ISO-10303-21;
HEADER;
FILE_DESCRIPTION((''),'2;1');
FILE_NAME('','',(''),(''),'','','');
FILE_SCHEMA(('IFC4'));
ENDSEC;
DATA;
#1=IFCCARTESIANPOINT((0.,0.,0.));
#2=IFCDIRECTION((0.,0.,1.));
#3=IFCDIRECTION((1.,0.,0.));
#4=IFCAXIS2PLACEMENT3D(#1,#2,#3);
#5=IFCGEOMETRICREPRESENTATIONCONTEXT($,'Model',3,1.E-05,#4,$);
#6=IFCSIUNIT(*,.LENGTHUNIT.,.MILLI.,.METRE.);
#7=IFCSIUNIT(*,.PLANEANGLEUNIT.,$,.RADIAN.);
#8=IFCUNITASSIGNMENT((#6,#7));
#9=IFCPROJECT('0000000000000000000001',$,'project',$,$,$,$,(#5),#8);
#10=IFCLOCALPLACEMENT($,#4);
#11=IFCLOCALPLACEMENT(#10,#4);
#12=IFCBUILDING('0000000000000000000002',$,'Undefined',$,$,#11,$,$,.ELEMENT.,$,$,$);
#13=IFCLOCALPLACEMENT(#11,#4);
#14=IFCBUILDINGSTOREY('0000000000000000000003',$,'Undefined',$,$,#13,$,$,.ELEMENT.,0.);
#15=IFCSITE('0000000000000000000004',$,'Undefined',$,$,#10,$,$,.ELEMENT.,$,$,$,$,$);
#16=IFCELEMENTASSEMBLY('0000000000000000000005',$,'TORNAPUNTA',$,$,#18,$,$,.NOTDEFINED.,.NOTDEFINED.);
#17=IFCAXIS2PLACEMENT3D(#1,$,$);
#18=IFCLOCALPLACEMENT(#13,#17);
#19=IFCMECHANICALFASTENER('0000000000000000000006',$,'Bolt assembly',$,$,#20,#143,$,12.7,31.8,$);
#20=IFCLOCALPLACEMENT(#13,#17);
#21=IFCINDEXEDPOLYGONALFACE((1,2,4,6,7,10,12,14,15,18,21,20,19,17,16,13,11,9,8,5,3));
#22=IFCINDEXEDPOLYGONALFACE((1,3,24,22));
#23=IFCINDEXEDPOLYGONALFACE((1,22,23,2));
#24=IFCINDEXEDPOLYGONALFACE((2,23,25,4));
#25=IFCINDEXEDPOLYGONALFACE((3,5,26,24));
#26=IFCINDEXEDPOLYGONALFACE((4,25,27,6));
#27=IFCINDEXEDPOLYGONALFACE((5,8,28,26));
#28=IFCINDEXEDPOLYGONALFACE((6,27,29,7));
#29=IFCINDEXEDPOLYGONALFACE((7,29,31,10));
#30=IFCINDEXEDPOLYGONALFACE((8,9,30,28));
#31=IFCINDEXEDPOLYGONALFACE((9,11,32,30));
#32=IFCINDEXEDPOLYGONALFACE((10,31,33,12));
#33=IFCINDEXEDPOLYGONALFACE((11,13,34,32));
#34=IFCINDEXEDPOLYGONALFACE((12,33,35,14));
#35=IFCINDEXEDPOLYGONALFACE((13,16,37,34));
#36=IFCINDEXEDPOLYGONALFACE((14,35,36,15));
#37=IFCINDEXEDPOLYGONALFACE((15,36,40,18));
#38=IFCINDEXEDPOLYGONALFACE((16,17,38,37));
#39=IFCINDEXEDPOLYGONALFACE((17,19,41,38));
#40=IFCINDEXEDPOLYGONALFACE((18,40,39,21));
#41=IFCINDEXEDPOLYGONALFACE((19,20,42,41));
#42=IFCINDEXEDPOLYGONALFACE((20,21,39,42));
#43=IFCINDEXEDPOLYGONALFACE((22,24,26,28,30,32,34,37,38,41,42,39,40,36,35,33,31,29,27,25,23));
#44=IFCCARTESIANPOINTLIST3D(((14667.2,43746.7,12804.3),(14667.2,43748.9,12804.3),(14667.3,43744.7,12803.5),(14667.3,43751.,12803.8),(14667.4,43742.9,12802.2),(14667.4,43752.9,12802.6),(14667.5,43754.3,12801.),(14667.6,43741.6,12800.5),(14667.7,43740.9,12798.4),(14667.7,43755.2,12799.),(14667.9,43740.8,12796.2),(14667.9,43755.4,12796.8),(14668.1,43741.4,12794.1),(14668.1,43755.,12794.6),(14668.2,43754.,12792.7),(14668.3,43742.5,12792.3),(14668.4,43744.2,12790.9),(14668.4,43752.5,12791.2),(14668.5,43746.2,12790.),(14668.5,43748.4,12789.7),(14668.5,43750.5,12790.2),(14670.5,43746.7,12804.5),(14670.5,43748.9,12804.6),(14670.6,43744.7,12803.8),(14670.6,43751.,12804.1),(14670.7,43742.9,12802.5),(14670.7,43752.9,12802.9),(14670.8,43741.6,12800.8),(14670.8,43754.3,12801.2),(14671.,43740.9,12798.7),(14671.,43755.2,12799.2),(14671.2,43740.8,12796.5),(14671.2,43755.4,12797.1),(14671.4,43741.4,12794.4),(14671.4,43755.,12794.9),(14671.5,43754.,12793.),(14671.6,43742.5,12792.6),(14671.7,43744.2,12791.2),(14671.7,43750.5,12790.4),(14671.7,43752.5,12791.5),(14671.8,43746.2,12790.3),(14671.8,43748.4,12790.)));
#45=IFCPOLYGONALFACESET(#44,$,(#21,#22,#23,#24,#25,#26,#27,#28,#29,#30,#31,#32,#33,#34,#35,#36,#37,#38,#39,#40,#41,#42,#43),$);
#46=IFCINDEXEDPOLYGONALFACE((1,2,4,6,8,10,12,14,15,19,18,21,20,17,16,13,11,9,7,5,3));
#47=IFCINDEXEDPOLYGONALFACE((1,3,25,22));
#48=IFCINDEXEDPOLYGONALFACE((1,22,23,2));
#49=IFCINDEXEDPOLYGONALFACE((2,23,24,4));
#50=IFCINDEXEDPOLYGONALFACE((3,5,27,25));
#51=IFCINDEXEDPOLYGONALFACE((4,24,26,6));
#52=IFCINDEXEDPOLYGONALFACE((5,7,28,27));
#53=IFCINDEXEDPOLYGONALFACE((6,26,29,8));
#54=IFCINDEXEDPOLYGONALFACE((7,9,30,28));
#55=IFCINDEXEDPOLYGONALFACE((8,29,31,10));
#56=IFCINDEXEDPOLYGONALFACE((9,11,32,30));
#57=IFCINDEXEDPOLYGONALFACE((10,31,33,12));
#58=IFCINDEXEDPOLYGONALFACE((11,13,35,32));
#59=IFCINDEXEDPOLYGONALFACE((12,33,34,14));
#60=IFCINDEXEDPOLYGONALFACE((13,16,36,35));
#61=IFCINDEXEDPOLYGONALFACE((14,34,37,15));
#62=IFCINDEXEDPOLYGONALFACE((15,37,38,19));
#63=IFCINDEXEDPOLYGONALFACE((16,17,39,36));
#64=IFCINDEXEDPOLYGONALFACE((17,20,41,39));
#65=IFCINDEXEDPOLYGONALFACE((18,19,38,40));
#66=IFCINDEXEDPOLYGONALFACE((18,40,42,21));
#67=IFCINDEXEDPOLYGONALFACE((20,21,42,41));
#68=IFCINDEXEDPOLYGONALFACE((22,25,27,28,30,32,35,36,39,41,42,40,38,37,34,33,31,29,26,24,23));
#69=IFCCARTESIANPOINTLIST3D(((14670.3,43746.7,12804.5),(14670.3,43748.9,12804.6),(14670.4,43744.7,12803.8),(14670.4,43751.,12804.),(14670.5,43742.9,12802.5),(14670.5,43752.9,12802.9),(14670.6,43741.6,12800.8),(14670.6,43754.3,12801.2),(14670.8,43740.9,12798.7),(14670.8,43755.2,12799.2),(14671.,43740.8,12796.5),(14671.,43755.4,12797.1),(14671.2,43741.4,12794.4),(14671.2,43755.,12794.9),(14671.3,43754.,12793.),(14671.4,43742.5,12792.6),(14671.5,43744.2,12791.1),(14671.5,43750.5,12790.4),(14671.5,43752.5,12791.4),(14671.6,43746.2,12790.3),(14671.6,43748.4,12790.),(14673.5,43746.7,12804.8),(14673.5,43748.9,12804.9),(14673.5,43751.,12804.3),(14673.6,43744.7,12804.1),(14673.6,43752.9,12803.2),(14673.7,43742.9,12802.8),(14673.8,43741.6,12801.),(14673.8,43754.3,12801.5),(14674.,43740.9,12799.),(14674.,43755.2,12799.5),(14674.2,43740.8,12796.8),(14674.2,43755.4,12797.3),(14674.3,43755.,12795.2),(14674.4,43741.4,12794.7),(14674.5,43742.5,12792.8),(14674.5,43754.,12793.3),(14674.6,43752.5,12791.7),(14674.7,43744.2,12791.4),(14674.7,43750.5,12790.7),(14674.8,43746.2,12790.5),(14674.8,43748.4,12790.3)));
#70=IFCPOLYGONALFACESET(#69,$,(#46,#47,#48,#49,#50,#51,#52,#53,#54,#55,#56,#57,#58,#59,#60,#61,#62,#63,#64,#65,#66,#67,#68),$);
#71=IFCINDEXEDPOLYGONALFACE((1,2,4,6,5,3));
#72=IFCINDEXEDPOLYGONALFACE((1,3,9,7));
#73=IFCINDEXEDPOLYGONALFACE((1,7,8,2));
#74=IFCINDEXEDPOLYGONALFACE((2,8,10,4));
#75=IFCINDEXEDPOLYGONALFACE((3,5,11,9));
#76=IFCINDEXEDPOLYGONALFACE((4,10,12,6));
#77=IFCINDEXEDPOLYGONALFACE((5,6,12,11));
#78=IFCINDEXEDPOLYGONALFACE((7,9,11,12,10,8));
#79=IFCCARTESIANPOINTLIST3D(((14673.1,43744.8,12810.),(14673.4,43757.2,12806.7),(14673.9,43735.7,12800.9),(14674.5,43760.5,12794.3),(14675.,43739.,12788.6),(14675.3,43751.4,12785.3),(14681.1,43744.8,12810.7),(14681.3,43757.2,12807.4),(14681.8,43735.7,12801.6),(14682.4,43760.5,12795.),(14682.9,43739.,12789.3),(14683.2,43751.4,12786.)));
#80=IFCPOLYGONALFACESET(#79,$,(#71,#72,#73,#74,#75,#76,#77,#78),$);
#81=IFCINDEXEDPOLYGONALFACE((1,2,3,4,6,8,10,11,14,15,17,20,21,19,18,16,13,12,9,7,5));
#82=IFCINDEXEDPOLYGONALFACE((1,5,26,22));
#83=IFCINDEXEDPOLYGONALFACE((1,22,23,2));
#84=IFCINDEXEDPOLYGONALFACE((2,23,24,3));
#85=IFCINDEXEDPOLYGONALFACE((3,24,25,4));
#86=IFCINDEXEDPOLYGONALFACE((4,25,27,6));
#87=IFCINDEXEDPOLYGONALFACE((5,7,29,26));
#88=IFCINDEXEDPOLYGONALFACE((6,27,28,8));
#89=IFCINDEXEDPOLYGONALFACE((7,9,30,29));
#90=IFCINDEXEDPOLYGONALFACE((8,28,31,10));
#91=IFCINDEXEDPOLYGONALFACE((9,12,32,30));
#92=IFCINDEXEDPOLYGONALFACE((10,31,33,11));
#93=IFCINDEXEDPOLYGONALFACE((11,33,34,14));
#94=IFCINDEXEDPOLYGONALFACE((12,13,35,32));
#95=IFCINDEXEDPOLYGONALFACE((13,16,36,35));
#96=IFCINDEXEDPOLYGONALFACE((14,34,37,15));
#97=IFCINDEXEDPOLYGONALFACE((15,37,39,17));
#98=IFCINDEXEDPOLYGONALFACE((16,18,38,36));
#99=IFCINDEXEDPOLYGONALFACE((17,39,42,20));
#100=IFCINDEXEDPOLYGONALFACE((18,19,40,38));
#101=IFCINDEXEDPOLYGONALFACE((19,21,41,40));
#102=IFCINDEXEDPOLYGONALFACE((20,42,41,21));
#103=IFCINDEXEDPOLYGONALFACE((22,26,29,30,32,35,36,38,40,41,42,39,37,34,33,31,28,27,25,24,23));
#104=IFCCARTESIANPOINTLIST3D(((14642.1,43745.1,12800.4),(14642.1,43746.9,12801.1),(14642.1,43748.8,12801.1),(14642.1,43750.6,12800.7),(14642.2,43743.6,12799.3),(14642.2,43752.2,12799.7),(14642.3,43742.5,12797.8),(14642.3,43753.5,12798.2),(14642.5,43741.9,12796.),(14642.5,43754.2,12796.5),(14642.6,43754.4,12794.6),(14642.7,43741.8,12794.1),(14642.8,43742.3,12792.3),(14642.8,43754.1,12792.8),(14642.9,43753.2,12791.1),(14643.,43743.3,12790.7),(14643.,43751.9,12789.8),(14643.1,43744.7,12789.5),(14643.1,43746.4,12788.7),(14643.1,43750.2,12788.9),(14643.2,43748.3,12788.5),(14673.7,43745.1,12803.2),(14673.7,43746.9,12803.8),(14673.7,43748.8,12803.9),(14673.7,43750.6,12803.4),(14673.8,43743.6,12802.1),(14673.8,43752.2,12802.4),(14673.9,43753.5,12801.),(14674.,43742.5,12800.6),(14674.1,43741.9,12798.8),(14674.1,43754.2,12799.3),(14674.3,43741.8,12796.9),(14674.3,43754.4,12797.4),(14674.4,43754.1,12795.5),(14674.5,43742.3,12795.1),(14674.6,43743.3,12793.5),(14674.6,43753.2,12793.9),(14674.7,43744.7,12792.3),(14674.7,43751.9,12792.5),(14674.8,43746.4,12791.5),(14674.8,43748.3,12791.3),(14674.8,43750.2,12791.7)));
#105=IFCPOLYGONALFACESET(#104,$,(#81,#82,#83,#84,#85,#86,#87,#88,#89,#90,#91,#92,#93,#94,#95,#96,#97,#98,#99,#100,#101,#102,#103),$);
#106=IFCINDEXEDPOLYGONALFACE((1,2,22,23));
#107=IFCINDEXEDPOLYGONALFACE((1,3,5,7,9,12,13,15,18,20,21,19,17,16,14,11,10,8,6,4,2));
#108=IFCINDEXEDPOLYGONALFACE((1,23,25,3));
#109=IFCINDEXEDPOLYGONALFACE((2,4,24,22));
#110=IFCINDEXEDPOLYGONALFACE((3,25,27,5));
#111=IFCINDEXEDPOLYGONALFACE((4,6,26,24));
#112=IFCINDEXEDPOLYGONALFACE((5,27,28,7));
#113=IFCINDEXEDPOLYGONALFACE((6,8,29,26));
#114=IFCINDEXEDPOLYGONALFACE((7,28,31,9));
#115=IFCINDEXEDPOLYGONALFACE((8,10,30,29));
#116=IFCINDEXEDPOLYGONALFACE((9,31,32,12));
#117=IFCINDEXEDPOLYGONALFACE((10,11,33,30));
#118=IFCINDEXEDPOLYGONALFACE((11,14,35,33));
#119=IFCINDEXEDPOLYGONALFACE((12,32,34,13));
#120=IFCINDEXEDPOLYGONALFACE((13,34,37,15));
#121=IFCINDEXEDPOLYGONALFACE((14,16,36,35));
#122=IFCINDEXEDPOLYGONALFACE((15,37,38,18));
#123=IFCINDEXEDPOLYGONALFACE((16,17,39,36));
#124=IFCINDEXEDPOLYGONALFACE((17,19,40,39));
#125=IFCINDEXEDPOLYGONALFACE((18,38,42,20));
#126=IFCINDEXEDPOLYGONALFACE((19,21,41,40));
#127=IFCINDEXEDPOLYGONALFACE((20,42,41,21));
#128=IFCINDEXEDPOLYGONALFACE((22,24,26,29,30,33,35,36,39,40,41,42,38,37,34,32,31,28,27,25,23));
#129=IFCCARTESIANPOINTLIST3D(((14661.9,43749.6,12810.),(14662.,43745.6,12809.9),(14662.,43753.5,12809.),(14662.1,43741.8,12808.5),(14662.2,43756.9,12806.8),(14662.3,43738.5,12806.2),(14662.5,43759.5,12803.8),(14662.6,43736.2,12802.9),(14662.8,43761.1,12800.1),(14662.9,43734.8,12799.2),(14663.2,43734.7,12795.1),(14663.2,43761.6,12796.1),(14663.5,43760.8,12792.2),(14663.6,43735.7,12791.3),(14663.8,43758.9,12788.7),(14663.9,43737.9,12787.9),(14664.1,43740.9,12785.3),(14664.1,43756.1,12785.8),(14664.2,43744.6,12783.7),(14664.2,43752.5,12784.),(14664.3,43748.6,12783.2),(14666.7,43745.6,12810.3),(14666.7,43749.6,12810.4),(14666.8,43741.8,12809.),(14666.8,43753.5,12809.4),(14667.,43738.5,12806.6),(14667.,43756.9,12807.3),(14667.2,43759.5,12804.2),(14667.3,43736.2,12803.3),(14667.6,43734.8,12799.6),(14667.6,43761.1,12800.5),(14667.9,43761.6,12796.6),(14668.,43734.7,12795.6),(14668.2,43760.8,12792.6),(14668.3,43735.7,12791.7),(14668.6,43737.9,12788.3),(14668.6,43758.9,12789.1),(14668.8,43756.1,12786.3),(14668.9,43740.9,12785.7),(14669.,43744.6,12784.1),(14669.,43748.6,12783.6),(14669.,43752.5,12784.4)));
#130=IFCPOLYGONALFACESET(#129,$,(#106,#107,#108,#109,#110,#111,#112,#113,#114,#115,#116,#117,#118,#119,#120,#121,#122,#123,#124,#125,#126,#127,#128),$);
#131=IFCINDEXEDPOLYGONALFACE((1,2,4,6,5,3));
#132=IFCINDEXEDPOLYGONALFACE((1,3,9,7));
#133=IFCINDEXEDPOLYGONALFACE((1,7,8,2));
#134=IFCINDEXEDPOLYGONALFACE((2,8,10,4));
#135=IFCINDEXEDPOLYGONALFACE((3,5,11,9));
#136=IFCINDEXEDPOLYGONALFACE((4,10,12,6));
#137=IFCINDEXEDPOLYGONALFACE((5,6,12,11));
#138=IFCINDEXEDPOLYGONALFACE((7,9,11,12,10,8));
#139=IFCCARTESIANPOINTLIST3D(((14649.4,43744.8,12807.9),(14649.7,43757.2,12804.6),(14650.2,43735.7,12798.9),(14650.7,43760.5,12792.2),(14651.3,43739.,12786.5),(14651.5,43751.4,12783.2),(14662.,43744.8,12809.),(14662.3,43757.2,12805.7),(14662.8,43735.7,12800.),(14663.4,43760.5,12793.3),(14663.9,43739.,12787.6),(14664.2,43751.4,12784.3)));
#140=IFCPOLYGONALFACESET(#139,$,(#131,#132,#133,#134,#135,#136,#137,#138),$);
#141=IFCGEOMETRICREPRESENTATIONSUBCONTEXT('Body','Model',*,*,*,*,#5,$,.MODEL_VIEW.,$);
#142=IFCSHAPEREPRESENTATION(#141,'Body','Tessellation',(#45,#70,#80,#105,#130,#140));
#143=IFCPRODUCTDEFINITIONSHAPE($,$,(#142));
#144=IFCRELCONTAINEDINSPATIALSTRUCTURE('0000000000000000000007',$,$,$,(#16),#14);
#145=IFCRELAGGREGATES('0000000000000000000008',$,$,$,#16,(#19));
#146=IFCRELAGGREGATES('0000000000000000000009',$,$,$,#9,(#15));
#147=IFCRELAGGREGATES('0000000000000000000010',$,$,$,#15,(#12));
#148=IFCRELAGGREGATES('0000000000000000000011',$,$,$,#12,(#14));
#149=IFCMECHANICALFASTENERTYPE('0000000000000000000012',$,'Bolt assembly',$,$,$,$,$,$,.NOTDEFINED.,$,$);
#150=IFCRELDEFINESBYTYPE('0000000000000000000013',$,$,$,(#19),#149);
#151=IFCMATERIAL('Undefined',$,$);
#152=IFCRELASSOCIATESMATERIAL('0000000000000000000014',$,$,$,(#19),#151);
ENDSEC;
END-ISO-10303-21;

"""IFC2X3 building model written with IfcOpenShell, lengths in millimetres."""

from ifc_helpers import new_model, si_unit, frame, origin_with_axes, origin_2d_with_axis, place, context, subcontext, project, spatial, polyline, circle, outline, extrude, source, transform, mapped, material, type_object, element, aggregate, save


model = new_model("IFC2X3")

# Units and contexts
model_context = context("Model", 3, precision=1e-05, world=origin_with_axes())
body_context = subcontext(model_context, "Body", "Model", "MODEL_VIEW")
ifc_project = project(units=[si_unit("LENGTHUNIT", "METRE", prefix="MILLI"), si_unit("PLANEANGLEUNIT", "RADIAN")], contexts=[model_context])

# Site, building, storey
site_placement = place(None, origin_with_axes())
site = spatial("IfcSite", under=ifc_project, at=site_placement, Name="Undefined", CompositionType="ELEMENT")
building_placement = place(site_placement, origin_with_axes())
building = spatial("IfcBuilding", under=site, at=building_placement, Name="Undefined", CompositionType="ELEMENT")
storey_placement = place(building_placement, origin_with_axes())
storey = spatial("IfcBuildingStorey", under=building, at=storey_placement, Name="Undefined", CompositionType="ELEMENT", Elevation=0.0)

# Shared definitions
ifc_material_1 = material(Name="Undefined")
mechanical_fastener_type = type_object("IfcMechanicalFastenerType", Name="Bolt assembly")
shared_shape_1 = source(origin_with_axes(), body_context, "Body", "SweptSolid", [
    extrude(circle(Radius=7.3, at=origin_2d_with_axis()), frame((0.0, -0.1, 0.0), z_axis=(0.0, 1.0, 0.0), x_axis=(1.0, 0.0, 0.0)), (0.0, 0.0, 1.0), 3.3),
    extrude(circle(Radius=7.3, at=origin_2d_with_axis()), frame((0.0, -3.1, 0.0), z_axis=(0.0, 1.0, 0.0), x_axis=(1.0, 0.0, 0.0)), (0.0, 0.0, 1.0), 3.2),
    extrude(outline(polyline([(11.1, -6.4), (11.1, 6.4), (0.0, 12.8), (-11.1, 6.4), (-11.1, -6.4), (0.0, -12.8), (11.1, -6.4)])), frame((0.0, -11.1, 0.0), z_axis=(0.0, 1.0, 0.0), x_axis=(1.0, 0.0, 0.0)), (0.0, 0.0, 1.0), 7.9),
    extrude(circle(Radius=6.3, at=origin_2d_with_axis()), frame((0.0, -3.2, 0.0), z_axis=(0.0, 1.0, 0.0), x_axis=(1.0, 0.0, 0.0)), (0.0, 0.0, 1.0), 31.8),
    extrude(circle(Radius=13.5, at=origin_2d_with_axis()), frame((0.0, 3.2, 0.0), z_axis=(0.0, 1.0, 0.0), x_axis=(1.0, 0.0, 0.0)), (0.0, 0.0, 1.0), 4.8),
    extrude(outline(polyline([(11.1, -6.4), (11.1, 6.4), (0.0, 12.8), (-11.1, 6.4), (-11.1, -6.4), (0.0, -12.8), (11.1, -6.4)])), frame((0.0, 8.0, 0.0), z_axis=(0.0, 1.0, 0.0), x_axis=(1.0, 0.0, 0.0)), (0.0, 0.0, 1.0), 12.7),
])

# Element assembly, mechanical fastener
assembly_1_placement = place(storey_placement, origin_with_axes())
assembly_1 = element("IfcElementAssembly", 1, at=assembly_1_placement, inside=storey, Name="TORNAPUNTA", AssemblyPlace="NOTDEFINED", PredefinedType="NOTDEFINED")
mechanical_fastener_1_placement = place(assembly_1_placement, frame((14671.0, 43748.1, 12797.3), z_axis=(0.061628, -0.707107, -0.704416), x_axis=(-0.061628, -0.707107, 0.704416)))
mechanical_fastener_1 = element("IfcMechanicalFastener", 2, at=mechanical_fastener_1_placement, type_object=mechanical_fastener_type, material=ifc_material_1, Name="Bolt assembly", NominalDiameter=12.7, NominalLength=31.8, context=body_context, shape_type="MappedRepresentation", body=[
    mapped(shared_shape_1, transform((0.0, 0.0, 0.0))),
])
aggregate(assembly_1, [mechanical_fastener_1])

save(model, "model.ifc")
